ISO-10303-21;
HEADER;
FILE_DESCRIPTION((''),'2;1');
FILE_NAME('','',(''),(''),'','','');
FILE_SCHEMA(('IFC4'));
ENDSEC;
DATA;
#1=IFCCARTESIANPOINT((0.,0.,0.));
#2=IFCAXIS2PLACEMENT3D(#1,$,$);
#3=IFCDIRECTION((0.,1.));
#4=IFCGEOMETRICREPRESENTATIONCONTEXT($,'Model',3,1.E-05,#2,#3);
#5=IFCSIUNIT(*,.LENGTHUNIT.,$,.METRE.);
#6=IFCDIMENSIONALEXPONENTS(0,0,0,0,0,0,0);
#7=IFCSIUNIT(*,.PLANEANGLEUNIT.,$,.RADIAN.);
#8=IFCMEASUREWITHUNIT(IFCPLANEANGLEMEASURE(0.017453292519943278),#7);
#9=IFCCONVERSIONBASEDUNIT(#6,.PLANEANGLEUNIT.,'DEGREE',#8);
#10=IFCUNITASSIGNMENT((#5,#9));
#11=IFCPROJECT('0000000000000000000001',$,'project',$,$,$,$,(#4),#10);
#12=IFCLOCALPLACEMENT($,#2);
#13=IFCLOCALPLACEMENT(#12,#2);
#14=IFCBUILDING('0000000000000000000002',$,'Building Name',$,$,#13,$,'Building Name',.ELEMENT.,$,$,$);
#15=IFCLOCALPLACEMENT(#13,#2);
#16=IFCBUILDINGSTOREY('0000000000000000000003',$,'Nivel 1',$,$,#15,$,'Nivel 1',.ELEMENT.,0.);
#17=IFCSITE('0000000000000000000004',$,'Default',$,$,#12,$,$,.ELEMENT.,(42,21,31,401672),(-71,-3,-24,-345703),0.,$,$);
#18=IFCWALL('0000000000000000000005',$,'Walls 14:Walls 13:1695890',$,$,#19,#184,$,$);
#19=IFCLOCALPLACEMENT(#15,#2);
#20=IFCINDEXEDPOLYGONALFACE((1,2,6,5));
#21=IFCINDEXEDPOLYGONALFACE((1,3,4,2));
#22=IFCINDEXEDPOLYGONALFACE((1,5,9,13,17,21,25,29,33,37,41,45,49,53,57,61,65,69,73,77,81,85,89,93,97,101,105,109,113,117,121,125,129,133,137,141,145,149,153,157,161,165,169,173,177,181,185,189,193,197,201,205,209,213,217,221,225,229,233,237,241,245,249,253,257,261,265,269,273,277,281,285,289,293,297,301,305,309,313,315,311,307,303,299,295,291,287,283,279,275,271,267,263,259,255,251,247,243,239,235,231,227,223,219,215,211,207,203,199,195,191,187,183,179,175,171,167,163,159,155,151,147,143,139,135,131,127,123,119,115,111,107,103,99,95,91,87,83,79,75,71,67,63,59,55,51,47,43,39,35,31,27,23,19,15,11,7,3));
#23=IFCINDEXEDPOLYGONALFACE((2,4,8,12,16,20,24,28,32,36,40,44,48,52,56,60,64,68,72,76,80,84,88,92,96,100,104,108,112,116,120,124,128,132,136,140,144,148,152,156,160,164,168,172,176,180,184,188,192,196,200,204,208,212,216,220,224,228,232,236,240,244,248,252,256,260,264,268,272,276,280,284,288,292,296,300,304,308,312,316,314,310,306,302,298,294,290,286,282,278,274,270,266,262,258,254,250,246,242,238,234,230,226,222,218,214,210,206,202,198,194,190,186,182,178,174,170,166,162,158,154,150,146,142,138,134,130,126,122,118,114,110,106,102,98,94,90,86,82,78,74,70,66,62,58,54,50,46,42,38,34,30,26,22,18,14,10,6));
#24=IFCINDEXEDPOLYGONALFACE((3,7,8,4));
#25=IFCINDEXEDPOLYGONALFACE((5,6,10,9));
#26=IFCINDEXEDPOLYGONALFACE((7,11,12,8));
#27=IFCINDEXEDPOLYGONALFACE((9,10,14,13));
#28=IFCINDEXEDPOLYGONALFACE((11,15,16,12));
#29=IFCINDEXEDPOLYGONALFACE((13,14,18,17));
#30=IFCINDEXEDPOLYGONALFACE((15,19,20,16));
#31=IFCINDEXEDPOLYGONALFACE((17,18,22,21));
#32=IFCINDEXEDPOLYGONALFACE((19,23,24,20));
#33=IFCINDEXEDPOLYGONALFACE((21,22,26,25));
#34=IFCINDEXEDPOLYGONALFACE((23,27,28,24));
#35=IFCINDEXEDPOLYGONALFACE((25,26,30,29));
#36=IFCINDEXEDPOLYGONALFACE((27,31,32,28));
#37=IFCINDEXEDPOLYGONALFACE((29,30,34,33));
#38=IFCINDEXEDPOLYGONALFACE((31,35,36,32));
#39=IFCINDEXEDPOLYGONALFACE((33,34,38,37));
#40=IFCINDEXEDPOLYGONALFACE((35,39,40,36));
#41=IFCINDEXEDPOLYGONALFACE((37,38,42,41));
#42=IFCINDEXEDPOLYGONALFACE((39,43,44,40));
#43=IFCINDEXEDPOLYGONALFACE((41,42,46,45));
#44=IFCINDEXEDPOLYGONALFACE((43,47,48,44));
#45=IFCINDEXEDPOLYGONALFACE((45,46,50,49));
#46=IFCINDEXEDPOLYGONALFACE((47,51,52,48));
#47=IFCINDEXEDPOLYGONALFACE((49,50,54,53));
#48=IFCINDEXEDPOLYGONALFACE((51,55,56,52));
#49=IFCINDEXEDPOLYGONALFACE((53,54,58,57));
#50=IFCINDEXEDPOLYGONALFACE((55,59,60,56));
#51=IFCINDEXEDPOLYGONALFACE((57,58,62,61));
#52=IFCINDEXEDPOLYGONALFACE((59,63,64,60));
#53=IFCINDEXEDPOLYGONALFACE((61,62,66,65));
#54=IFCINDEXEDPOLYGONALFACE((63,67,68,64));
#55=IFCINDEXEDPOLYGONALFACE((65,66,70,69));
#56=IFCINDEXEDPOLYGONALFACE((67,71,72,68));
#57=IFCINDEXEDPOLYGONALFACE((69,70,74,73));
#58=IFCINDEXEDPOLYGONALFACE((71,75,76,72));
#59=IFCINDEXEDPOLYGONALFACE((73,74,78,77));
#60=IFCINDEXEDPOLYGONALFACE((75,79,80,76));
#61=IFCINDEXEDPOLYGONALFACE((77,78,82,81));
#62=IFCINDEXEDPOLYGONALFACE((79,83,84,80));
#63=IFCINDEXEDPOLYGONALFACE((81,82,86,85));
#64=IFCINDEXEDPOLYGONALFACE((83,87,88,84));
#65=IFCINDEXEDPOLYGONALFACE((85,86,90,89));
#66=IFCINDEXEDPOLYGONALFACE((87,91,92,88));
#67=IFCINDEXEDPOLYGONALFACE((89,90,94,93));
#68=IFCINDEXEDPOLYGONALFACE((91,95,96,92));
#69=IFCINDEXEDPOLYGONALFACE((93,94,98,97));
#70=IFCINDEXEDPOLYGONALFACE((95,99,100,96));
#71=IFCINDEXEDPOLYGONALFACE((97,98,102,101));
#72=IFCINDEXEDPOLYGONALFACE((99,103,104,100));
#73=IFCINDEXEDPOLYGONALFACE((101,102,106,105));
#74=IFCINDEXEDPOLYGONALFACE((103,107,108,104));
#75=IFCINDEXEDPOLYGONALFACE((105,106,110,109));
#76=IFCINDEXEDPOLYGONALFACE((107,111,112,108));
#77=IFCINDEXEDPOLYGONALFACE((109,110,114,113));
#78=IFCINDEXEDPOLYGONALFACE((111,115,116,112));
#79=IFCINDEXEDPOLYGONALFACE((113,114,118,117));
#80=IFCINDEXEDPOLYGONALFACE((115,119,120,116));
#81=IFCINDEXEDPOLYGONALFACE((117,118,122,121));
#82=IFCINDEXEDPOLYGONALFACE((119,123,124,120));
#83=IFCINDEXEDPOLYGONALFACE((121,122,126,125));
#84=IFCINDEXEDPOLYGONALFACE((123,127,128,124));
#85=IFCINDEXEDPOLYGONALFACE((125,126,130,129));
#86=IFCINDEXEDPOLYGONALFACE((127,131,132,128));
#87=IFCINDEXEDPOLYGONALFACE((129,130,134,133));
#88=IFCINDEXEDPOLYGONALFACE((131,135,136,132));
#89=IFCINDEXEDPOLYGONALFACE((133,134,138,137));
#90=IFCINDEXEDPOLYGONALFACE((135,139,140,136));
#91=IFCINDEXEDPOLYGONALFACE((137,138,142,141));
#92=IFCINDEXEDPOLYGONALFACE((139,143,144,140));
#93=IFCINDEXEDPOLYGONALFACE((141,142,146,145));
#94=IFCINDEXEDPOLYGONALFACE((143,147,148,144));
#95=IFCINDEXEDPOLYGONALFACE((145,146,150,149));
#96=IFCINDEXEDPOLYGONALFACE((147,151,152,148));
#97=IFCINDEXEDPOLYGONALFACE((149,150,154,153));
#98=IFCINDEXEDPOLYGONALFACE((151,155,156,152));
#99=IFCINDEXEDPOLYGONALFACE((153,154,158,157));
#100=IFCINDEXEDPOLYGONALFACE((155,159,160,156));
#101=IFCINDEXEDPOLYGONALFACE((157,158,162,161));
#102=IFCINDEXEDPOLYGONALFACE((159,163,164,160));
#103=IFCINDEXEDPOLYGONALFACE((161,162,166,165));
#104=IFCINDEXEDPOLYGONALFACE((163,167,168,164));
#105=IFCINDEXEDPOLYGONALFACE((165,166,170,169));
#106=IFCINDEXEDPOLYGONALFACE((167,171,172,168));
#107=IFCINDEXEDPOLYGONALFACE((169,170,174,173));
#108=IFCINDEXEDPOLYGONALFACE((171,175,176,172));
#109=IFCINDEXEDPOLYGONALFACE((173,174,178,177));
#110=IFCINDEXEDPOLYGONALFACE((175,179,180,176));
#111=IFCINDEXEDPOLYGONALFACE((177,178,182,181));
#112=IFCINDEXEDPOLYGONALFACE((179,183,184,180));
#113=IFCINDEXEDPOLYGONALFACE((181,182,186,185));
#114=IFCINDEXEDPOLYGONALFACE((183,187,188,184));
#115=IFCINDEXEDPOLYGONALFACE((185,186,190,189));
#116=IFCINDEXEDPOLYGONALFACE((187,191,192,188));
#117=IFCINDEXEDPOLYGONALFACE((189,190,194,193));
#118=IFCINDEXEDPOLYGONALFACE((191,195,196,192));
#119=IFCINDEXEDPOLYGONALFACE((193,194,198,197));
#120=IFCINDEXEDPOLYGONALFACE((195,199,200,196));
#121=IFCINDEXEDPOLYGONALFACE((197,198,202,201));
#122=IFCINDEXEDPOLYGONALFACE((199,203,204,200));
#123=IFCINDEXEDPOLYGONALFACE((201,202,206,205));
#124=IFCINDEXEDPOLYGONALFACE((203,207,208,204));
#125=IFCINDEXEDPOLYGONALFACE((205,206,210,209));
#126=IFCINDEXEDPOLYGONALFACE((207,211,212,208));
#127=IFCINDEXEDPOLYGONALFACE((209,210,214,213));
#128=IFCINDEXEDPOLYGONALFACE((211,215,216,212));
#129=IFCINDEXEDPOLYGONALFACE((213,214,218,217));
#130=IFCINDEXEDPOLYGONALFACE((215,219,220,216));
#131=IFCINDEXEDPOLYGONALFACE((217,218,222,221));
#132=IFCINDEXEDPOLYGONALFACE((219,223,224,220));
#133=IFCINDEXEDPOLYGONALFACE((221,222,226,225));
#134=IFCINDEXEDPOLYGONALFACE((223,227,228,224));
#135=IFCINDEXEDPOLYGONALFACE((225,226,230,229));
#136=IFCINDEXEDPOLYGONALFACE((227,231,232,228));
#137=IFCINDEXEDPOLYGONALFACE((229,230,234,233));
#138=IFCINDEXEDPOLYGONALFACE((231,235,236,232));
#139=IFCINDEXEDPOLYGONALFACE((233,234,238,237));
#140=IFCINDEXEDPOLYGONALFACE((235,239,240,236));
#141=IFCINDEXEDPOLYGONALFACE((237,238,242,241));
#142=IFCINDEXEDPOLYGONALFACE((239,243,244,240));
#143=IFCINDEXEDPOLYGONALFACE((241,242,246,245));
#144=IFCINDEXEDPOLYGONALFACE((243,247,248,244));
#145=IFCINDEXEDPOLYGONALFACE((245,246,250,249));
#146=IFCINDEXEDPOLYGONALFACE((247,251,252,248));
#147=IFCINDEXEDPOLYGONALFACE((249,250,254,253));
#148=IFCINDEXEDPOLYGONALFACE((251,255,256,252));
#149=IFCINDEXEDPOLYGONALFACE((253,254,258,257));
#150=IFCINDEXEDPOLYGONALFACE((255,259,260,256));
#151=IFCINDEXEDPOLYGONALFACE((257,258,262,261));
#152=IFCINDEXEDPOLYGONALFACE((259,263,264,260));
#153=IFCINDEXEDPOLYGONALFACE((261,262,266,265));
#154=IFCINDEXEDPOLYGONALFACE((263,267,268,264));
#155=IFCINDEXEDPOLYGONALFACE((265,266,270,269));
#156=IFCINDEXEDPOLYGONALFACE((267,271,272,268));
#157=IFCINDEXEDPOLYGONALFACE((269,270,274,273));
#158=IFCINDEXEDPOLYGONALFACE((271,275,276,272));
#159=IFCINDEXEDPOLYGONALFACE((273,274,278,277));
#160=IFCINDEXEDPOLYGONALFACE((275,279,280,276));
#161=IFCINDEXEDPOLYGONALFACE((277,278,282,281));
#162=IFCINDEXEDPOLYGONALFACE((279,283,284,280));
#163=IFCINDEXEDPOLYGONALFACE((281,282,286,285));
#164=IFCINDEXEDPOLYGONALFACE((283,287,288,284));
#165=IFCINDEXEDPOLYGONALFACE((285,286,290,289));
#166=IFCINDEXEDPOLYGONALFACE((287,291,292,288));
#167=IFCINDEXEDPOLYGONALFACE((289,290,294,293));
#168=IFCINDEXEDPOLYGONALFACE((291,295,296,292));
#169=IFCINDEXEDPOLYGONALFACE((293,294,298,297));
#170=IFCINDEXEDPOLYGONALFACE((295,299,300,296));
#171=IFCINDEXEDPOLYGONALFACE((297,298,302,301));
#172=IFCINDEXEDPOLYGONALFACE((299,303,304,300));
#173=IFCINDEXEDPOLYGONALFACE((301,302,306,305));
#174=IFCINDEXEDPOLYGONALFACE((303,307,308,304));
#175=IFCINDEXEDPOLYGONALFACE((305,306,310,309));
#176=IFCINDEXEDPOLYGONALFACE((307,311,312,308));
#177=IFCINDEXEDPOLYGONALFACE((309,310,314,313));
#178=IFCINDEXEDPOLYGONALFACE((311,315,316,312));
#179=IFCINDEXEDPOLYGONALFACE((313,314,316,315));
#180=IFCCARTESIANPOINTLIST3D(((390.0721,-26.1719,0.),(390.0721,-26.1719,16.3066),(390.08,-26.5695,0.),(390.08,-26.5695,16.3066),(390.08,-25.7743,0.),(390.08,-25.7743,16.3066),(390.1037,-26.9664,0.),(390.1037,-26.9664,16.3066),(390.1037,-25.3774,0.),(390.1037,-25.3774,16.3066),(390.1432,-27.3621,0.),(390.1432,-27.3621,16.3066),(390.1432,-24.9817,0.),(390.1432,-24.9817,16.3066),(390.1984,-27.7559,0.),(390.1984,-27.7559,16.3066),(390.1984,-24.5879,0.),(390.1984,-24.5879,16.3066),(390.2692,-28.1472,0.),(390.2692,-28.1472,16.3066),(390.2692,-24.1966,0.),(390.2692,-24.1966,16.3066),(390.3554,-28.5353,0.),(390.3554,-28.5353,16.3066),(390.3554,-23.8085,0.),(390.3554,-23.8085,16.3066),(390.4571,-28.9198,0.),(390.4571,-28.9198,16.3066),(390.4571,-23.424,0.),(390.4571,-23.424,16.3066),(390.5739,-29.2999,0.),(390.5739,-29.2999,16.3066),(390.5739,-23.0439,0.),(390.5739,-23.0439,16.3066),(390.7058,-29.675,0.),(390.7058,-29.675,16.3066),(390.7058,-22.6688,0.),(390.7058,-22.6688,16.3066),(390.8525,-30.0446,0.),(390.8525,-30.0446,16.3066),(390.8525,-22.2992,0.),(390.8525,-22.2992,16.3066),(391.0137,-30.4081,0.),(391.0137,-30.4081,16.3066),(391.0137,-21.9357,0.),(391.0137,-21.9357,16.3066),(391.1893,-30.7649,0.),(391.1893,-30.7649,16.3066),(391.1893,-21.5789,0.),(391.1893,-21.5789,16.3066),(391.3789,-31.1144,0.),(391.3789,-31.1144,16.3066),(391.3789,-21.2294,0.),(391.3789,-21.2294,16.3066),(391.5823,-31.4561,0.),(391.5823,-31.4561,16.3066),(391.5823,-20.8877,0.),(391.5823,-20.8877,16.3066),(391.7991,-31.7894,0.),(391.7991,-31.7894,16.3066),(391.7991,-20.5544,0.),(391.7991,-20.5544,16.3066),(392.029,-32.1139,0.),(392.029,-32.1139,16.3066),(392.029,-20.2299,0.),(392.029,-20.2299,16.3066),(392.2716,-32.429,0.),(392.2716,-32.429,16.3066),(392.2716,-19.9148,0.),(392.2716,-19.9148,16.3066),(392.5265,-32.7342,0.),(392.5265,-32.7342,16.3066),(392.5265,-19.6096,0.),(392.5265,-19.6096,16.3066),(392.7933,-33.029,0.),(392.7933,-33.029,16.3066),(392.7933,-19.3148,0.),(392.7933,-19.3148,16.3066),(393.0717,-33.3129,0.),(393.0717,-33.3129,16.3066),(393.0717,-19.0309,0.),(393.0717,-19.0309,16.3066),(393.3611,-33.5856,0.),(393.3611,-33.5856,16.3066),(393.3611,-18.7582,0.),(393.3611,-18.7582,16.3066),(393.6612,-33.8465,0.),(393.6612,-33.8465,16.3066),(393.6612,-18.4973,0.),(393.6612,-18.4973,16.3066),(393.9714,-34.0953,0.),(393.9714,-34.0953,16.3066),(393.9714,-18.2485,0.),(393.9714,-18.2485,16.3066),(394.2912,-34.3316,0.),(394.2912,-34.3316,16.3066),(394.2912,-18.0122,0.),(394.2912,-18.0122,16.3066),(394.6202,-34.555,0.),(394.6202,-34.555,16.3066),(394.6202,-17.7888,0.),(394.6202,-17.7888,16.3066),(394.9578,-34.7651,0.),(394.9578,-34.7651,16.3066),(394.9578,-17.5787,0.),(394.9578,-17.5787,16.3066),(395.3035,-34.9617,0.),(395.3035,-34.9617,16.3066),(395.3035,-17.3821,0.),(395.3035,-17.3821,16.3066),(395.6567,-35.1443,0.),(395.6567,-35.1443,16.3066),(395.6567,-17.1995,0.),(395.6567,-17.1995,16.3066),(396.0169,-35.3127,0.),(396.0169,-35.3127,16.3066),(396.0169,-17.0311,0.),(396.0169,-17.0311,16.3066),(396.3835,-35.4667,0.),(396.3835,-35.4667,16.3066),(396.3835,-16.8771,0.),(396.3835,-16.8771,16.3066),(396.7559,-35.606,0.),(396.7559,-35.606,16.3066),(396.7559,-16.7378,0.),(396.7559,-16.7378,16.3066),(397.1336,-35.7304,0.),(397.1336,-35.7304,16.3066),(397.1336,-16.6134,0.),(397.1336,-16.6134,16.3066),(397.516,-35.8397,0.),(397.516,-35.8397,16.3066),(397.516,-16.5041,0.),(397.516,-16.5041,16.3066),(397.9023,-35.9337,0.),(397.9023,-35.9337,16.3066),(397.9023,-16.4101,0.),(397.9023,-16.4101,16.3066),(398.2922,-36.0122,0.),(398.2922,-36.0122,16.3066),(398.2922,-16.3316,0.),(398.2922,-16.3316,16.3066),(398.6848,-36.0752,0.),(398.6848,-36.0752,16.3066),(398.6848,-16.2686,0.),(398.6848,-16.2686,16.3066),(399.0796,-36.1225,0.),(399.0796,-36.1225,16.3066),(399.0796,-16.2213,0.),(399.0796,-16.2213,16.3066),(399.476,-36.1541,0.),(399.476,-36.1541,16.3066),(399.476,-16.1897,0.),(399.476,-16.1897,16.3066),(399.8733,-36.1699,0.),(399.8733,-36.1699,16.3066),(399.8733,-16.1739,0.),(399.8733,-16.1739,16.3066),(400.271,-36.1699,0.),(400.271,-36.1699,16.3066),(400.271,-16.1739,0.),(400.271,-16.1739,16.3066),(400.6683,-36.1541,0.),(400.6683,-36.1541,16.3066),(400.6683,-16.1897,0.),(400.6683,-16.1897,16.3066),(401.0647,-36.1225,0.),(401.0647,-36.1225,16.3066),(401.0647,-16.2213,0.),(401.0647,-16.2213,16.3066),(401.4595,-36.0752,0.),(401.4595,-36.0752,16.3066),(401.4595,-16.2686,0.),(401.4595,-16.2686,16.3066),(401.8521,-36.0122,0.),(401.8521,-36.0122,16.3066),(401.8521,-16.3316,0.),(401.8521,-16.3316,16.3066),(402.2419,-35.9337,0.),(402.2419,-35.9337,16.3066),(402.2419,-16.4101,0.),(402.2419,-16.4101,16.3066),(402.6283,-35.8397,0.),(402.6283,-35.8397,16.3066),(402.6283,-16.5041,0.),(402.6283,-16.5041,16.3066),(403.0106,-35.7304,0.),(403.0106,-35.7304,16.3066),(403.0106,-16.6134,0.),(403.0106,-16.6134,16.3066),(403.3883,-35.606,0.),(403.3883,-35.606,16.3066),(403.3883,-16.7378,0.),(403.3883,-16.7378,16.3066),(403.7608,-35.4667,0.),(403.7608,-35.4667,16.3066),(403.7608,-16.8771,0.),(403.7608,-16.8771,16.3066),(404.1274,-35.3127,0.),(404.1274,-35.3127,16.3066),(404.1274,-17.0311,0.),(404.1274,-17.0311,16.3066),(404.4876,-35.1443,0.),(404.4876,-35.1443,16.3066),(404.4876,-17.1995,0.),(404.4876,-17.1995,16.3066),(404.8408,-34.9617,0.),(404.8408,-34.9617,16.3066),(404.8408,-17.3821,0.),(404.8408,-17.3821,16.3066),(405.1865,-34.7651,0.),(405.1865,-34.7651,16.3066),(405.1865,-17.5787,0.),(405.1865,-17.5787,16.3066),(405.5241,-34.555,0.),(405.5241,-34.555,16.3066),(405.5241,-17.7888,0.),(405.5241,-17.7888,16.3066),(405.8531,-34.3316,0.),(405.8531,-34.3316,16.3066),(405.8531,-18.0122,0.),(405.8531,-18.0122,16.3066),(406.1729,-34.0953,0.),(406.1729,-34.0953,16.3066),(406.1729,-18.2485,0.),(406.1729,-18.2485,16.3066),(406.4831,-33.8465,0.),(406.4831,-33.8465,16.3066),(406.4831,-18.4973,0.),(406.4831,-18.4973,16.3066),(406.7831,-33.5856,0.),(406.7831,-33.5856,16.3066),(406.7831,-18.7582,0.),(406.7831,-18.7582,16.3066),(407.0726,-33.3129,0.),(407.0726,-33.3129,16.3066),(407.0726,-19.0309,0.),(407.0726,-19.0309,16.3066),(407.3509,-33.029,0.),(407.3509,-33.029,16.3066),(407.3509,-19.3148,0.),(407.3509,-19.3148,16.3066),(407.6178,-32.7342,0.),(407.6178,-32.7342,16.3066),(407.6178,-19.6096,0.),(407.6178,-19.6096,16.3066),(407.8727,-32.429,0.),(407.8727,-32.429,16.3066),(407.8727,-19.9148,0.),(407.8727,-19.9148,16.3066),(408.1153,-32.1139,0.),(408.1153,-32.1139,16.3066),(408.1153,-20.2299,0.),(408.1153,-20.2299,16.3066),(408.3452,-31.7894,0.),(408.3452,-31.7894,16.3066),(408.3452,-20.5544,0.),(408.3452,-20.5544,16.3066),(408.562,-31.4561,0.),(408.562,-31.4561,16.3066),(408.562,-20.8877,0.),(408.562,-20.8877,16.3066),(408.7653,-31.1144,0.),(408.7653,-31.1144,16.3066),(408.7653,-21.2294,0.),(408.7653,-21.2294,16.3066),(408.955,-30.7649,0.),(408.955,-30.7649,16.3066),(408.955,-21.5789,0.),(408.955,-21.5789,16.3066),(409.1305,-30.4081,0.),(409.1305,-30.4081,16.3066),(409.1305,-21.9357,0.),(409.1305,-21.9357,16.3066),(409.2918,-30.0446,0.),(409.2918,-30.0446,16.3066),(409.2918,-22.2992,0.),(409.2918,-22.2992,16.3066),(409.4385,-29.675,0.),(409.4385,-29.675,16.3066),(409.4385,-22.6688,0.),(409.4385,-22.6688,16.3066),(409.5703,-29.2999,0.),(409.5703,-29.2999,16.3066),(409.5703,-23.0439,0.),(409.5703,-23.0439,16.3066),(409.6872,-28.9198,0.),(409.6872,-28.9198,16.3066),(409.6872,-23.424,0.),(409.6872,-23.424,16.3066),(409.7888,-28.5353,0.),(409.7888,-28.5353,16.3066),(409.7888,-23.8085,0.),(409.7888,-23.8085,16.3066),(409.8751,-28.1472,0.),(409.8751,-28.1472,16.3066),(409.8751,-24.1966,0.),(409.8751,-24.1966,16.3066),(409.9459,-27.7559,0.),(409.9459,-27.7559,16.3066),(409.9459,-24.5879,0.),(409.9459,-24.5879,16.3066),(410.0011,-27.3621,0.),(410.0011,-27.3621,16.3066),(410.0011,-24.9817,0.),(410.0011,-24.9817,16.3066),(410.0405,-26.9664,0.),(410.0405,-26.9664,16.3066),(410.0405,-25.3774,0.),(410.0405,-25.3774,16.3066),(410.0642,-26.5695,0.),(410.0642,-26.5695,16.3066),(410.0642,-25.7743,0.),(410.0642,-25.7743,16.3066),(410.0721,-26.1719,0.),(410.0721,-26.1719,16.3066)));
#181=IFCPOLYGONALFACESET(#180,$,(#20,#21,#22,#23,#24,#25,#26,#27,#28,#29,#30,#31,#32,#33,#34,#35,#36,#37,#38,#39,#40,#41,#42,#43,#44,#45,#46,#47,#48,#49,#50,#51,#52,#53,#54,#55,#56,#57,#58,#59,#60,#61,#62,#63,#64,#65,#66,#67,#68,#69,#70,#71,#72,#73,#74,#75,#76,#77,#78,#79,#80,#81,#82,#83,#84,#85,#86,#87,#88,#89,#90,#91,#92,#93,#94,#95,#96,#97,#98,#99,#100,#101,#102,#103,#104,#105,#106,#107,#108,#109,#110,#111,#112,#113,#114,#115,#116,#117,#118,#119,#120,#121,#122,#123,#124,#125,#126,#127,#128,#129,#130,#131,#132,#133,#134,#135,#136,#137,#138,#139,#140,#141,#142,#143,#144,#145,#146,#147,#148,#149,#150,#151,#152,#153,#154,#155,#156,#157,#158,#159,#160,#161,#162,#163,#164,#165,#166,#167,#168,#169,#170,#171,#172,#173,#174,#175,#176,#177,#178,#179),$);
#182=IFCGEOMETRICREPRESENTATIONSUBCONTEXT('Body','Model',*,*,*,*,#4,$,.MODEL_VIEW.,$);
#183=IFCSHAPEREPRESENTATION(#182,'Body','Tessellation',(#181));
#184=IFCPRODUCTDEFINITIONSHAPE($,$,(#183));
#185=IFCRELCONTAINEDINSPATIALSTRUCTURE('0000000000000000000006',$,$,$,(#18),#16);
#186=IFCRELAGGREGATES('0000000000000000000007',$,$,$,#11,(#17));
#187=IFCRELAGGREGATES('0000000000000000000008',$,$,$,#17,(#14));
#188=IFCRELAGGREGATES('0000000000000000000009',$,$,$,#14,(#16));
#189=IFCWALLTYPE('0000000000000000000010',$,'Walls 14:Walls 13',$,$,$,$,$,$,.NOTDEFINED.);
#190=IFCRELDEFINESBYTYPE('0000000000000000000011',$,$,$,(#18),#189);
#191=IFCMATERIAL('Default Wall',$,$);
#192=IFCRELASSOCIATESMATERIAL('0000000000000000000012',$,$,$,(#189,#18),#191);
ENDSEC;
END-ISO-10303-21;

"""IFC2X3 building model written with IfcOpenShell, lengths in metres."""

from ifc_helpers import new_model, entity, si_unit, converted_unit, direction, frame, frame_2d, origin, place, context, subcontext, project, spatial, circle, extrude, material, type_object, element, save


model = new_model("IFC2X3")

# Units and contexts
model_context = context("Model", 3, precision=1e-05, world=origin(), true_north=direction((0.0, 1.0)))
body_context = subcontext(model_context, "Body", "Model", "MODEL_VIEW")
ifc_project = project(units=[si_unit("LENGTHUNIT", "METRE"), converted_unit("PLANEANGLEUNIT", "DEGREE", entity("IfcPlaneAngleMeasure", 0.017453292519943278), si_unit("PLANEANGLEUNIT", "RADIAN"), dimensions=[0, 0, 0, 0, 0, 0, 0])], contexts=[model_context])

# Site, building, storey
site_placement = place(None, origin())
site = spatial("IfcSite", under=ifc_project, at=site_placement, Name="Default", CompositionType="ELEMENT", RefLatitude=(42, 21, 31, 401672), RefLongitude=(-71, -3, -24, -345703), RefElevation=0.0)
building_placement = place(site_placement, origin())
building = spatial("IfcBuilding", under=site, at=building_placement, Name="Building Name", LongName="Building Name", CompositionType="ELEMENT")
storey_placement = place(building_placement, origin())
storey = spatial("IfcBuildingStorey", under=building, at=storey_placement, Name="Nivel 1", LongName="Nivel 1", CompositionType="ELEMENT", Elevation=0.0)

# Wall
ifc_material_1 = material(Name="Default Wall")
wall_type_1 = type_object("IfcWallType", Name="Walls 14:Walls 13", PredefinedType="NOTDEFINED", material=ifc_material_1)
wall_1_placement = place(storey_placement, frame((390.0721, -36.1719, 0.0)))
element("IfcWall", 1, at=wall_1_placement, inside=storey, type_object=wall_type_1, material=ifc_material_1, Name="Walls 14:Walls 13:1695890", context=body_context, shape_type="SweptSolid", body=[
    extrude(circle(Radius=10.0, at=frame_2d((0.0, 0.0), x_axis=(1.0, 0.0))), frame((10.0, 10.0, 0.0)), (0.0, 0.0, 1.0), 16.3066),
])

save(model, "model.ifc")
